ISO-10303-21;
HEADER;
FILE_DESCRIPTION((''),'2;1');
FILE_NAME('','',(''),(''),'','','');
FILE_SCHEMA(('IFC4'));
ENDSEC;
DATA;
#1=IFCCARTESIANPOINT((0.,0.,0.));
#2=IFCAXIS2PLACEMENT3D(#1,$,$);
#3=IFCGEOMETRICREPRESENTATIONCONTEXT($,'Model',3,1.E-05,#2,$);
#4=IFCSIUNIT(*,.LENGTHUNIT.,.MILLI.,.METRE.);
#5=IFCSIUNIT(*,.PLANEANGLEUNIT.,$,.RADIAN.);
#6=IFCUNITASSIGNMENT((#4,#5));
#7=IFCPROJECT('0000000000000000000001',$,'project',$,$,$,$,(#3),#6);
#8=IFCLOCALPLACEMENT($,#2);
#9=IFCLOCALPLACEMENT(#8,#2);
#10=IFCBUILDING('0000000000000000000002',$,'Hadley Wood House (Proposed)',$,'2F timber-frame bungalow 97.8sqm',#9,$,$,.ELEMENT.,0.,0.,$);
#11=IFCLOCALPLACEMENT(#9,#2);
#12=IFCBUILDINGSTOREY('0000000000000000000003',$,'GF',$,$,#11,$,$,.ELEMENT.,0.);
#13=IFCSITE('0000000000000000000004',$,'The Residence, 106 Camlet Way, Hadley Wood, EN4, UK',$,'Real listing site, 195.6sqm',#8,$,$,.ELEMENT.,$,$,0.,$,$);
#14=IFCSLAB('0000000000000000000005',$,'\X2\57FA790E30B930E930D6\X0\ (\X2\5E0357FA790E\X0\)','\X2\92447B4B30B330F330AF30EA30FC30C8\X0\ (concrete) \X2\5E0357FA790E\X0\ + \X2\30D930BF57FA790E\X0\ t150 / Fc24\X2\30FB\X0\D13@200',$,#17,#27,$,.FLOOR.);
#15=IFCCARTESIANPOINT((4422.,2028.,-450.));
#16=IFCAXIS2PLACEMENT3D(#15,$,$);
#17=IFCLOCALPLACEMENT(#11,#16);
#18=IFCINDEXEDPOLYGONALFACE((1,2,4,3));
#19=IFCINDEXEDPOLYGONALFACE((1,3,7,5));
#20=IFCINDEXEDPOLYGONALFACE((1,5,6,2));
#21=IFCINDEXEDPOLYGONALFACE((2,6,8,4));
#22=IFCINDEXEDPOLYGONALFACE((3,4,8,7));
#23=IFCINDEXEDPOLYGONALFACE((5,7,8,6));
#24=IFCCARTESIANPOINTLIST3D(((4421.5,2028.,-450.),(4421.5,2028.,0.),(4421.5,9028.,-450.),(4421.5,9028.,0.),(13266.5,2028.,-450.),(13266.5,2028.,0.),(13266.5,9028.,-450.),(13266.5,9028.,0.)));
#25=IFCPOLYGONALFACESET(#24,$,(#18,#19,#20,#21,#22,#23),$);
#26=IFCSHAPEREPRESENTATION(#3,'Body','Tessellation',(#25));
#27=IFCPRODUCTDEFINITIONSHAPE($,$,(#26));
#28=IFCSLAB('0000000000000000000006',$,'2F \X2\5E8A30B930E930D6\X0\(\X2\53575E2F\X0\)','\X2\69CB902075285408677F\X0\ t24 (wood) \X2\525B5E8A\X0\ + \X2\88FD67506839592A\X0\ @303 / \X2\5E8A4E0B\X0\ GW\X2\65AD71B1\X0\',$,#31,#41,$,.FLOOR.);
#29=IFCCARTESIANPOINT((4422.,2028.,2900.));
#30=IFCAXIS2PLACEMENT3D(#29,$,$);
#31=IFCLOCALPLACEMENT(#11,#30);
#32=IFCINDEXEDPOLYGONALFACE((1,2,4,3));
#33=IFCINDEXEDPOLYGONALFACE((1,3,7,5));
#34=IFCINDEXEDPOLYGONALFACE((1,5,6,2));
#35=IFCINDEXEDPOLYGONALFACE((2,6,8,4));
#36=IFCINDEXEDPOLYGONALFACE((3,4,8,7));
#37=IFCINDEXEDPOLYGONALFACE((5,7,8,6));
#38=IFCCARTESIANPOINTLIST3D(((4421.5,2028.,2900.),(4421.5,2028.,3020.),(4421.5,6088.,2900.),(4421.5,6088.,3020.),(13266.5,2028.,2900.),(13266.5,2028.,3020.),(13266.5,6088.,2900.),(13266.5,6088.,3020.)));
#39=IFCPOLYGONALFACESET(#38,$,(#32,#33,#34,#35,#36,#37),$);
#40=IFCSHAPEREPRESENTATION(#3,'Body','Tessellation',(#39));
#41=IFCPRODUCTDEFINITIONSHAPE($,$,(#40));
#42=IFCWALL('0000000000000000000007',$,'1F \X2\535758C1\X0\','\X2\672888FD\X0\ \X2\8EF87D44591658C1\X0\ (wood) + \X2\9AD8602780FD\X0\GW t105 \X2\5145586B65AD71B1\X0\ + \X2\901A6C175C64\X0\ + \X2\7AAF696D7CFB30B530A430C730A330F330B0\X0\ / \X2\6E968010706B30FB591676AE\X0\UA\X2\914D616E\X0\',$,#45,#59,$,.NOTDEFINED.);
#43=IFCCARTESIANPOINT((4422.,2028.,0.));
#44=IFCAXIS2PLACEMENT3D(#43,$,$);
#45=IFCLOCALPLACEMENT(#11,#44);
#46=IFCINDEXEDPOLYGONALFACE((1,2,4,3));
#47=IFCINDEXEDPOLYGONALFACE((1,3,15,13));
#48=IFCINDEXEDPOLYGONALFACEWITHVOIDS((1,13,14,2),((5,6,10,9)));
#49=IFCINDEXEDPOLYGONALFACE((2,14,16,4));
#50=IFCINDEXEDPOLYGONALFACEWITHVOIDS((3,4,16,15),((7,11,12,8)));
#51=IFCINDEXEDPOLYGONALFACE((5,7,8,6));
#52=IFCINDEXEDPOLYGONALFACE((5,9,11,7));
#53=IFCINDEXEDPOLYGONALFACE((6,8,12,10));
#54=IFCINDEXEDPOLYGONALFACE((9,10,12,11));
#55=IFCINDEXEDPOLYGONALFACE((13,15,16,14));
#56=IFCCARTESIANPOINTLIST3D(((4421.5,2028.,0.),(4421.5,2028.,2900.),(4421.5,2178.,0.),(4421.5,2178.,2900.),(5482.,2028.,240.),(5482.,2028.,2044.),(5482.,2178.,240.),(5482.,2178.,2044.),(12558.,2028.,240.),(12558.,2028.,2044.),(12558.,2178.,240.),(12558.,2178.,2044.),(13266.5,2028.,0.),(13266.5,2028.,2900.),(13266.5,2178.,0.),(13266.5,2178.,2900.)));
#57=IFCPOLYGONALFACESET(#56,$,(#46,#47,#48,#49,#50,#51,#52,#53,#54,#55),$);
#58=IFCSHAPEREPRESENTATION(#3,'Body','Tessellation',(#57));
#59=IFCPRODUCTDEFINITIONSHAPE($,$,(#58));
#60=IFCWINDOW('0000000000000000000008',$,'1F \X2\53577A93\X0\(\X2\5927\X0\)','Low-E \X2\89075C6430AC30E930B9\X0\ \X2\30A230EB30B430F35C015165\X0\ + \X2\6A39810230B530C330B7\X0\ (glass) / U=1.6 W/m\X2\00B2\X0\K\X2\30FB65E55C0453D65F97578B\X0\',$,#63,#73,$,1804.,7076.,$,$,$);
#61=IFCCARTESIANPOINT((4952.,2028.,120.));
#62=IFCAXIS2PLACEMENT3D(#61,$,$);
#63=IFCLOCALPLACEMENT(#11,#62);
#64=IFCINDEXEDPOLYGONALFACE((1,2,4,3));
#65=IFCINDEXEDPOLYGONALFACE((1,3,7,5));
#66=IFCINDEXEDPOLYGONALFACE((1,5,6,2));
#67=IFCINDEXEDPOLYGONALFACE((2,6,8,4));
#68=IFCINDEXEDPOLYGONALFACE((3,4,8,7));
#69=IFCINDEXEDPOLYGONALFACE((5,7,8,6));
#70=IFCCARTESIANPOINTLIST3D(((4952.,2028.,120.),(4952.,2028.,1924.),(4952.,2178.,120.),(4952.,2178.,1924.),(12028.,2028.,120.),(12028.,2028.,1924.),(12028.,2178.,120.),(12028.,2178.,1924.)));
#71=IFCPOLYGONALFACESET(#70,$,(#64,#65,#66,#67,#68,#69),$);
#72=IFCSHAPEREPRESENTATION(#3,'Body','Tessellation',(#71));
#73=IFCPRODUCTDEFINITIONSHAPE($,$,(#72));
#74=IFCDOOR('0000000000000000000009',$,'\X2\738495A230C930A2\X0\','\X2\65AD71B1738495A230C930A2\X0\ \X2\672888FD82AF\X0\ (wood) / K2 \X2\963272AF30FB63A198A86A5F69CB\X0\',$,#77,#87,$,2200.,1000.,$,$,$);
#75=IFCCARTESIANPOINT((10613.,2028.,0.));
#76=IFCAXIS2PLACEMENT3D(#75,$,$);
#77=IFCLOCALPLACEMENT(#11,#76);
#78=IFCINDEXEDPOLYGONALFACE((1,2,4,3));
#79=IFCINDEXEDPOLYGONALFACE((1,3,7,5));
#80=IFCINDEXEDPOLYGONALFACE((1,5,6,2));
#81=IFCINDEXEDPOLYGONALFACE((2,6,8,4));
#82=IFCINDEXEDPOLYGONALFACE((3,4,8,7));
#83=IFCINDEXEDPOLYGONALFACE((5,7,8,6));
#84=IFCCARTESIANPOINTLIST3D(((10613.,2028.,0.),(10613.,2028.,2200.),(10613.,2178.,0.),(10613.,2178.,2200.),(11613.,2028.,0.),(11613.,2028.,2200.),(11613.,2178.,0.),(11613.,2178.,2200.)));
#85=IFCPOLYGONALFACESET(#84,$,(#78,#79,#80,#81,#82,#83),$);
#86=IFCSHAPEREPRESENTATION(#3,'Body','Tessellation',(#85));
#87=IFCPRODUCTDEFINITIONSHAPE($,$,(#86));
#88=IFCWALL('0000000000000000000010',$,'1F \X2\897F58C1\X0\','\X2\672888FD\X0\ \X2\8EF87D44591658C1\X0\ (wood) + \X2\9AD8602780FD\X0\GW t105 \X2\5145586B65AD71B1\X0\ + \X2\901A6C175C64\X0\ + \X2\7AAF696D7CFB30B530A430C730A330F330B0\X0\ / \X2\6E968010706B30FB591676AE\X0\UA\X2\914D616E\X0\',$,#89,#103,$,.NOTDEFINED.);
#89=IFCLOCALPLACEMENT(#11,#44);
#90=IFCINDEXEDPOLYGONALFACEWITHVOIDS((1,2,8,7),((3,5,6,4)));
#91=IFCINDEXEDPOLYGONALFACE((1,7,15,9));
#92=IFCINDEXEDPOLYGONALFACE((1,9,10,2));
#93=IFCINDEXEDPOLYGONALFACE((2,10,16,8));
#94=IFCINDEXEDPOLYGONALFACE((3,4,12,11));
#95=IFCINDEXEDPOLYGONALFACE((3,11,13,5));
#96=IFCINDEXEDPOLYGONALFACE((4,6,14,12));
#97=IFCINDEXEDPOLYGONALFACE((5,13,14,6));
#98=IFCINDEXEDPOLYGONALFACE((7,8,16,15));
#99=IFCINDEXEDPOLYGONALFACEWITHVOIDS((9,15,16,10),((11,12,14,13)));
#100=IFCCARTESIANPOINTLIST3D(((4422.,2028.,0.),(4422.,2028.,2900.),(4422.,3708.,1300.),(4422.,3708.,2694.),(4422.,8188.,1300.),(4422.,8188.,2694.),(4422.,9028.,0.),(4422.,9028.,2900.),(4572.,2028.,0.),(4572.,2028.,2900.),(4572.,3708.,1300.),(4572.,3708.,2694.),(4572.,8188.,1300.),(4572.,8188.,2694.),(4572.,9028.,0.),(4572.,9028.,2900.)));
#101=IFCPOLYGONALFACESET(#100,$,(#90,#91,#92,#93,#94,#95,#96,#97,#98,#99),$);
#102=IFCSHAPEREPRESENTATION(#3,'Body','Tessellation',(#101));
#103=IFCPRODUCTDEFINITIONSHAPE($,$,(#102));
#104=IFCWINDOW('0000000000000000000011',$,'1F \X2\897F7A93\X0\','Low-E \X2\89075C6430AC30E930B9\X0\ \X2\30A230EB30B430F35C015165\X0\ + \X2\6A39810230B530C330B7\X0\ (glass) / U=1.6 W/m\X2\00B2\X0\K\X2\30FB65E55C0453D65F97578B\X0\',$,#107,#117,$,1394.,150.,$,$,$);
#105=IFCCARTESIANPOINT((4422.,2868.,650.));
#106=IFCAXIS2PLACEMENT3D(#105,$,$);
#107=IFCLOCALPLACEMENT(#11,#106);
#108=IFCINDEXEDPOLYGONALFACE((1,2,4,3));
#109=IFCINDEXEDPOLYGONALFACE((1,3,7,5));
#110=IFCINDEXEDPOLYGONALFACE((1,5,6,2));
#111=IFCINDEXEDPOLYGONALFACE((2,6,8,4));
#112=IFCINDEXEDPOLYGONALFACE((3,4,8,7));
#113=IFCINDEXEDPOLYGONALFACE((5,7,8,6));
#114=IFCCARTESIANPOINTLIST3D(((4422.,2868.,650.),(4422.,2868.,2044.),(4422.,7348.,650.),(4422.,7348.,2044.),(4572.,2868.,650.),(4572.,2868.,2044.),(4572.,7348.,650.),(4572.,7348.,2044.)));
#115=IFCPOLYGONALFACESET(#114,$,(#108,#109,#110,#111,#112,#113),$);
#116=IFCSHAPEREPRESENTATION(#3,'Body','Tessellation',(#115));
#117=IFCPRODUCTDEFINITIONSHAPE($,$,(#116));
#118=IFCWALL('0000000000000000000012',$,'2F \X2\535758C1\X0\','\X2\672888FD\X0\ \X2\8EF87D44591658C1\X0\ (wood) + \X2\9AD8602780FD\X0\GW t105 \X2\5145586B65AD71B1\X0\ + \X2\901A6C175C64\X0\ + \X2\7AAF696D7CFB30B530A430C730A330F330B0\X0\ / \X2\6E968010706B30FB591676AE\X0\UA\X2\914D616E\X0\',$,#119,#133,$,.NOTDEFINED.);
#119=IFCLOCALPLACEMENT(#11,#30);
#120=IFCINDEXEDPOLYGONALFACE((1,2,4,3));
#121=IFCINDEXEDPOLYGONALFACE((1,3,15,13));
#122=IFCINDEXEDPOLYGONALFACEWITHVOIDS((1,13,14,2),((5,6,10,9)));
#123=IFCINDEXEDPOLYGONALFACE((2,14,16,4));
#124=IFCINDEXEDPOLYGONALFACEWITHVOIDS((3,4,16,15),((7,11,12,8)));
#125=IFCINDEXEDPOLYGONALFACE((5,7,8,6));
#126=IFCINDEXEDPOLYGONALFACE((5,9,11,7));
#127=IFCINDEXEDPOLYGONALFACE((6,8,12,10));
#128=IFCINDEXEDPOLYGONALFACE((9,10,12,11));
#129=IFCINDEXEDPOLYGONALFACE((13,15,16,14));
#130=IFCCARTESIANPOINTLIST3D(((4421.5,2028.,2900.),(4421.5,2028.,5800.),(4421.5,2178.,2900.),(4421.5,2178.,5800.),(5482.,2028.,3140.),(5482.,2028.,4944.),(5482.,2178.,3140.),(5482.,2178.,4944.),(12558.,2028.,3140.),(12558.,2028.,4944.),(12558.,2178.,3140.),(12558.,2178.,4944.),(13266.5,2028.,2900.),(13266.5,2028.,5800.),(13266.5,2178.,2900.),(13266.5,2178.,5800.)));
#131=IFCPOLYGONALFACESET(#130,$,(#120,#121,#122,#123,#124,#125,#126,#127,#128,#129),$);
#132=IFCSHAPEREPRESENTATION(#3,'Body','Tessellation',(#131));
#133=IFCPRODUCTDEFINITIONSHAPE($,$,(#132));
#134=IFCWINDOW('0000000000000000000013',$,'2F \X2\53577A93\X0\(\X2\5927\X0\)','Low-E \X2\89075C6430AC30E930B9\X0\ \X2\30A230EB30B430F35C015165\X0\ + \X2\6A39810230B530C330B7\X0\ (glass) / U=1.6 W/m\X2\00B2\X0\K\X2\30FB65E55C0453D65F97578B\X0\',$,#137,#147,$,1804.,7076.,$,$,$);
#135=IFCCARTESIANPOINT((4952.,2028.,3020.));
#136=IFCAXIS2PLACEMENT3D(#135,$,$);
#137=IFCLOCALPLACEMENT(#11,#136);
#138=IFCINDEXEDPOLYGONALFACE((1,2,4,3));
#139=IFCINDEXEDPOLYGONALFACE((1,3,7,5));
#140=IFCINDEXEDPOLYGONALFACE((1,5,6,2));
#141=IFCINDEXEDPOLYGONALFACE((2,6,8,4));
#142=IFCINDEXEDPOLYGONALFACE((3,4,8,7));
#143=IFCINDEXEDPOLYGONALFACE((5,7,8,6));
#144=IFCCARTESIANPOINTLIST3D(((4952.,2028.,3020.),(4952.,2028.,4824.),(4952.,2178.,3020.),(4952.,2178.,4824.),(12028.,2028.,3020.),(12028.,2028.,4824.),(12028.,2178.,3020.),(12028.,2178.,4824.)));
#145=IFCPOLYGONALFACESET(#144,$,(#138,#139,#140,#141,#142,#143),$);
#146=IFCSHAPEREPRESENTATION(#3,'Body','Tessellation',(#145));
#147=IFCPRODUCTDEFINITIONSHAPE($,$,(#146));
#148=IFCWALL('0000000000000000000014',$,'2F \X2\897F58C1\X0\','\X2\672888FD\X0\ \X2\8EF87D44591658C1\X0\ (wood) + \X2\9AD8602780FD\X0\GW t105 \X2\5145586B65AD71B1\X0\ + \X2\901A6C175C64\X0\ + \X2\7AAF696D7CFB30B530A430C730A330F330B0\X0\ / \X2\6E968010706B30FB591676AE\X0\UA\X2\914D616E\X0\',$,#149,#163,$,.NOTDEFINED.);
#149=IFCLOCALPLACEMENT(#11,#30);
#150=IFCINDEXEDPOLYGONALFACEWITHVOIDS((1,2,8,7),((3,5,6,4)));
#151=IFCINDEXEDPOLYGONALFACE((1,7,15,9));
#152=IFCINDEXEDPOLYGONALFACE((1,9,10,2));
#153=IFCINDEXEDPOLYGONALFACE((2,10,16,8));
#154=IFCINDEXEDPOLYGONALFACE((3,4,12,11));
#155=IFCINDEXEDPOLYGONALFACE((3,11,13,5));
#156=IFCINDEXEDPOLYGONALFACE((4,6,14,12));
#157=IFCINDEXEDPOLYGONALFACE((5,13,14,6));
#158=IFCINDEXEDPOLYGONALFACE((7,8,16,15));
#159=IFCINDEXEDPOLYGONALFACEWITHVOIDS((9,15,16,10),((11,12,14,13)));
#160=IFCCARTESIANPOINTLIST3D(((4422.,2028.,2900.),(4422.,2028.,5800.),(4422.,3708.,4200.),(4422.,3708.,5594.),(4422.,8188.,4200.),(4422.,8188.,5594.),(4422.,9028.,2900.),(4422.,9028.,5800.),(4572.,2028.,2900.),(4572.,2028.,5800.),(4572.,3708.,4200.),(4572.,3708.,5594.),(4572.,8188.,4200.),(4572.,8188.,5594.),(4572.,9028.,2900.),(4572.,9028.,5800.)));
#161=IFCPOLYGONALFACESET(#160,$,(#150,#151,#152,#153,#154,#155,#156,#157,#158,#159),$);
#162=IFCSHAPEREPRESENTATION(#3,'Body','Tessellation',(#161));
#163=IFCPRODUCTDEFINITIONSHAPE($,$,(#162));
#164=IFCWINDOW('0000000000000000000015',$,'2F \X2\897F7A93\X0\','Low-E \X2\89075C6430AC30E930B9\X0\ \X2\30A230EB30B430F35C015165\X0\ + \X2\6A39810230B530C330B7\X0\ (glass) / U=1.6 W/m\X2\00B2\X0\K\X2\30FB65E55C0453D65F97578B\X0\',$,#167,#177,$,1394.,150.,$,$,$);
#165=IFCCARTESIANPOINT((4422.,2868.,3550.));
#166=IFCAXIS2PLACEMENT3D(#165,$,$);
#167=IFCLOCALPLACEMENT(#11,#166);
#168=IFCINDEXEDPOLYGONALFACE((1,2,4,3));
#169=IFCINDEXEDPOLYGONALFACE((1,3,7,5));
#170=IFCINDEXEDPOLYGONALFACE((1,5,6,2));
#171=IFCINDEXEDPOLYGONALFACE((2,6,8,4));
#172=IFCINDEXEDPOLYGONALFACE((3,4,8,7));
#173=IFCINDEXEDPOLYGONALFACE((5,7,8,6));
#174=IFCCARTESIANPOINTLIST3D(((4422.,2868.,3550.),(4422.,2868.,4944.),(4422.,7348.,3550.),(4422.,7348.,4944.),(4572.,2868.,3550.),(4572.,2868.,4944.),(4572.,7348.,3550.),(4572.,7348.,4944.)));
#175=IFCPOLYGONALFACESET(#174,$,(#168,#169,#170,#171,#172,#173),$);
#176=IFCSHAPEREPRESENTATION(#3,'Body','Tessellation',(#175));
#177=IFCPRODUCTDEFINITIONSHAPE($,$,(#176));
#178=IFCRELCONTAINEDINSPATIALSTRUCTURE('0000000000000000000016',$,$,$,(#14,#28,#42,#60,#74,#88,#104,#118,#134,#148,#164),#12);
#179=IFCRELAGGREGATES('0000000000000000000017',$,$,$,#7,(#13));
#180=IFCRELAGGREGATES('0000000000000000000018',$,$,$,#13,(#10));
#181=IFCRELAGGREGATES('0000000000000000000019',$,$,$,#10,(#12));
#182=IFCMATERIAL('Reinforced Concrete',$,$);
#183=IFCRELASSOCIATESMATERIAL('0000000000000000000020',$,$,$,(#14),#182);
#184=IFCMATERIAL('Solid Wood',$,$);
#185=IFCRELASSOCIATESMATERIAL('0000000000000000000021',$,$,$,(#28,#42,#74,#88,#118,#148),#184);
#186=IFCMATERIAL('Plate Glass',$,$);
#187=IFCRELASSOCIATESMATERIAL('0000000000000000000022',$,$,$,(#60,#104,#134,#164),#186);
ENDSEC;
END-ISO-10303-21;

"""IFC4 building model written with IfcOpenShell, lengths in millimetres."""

from ifc_helpers import new_model, si_unit, frame, frame_2d, origin, place, context, project, spatial, rectangle, extrude, material, element, fill, save


model = new_model("IFC4")

# Units and contexts
model_context = context("Model", 3, precision=1e-05, world=origin())
ifc_project = project(units=[si_unit("LENGTHUNIT", "METRE", prefix="MILLI"), si_unit("PLANEANGLEUNIT", "RADIAN")], contexts=[model_context])

# Site, building, storey
site_placement = place(None, origin())
site = spatial("IfcSite", under=ifc_project, at=site_placement, Name="The Residence, 106 Camlet Way, Hadley Wood, EN4, UK", ObjectType="Real listing site, 195.6sqm", CompositionType="ELEMENT", RefElevation=0.0)
building_placement = place(site_placement, origin())
building = spatial("IfcBuilding", under=site, at=building_placement, Name="Hadley Wood House (Proposed)", ObjectType="2F timber-frame bungalow 97.8sqm", CompositionType="ELEMENT", ElevationOfRefHeight=0.0, ElevationOfTerrain=0.0)
storey_placement = place(building_placement, origin())
storey = spatial("IfcBuildingStorey", under=building, at=storey_placement, Name="GF", CompositionType="ELEMENT", Elevation=0.0)

# Slabs
ifc_material_1 = material(Name="Reinforced Concrete")
slab_1_placement = place(storey_placement, frame((4422.0, 2028.0, -450.0)))
element("IfcSlab", 1, at=slab_1_placement, inside=storey, material=ifc_material_1, Name="基礎スラブ (布基礎)", Description="鉄筋コンクリート (concrete) 布基礎 + ベタ基礎 t150 / Fc24・D13@200", PredefinedType="FLOOR", context=model_context, shape_type="SweptSolid", body=[
    extrude(rectangle(XDim=8845.0, YDim=7000.0, at=frame_2d((4422.0, 3500.0))), frame((4422.0, 2028.0, -450.0)), (0.0, 0.0, 1.0), 450.0),
])
ifc_material_2 = material(Name="Solid Wood")
slab_2_placement = place(storey_placement, frame((4422.0, 2028.0, 2900.0)))
element("IfcSlab", 2, at=slab_2_placement, inside=storey, material=ifc_material_2, Name="2F 床スラブ(南帯)", Description="構造用合板 t24 (wood) 剛床 + 製材根太 @303 / 床下 GW断熱", PredefinedType="FLOOR", context=model_context, shape_type="SweptSolid", body=[
    extrude(rectangle(XDim=8845.0, YDim=4060.0, at=frame_2d((4422.0, 2030.0))), frame((4422.0, 2028.0, 2900.0)), (0.0, 0.0, 1.0), 120.0),
])

# Wall, openings, window, door
wall_1_placement = place(storey_placement, frame((4422.0, 2028.0, 0.0)))
wall_1 = element("IfcWall", 3, at=wall_1_placement, inside=storey, material=ifc_material_2, Name="1F 南壁", Description="木製 軸組外壁 (wood) + 高性能GW t105 充填断熱 + 通気層 + 窯業系サイディング / 準耐火・外皮UA配慮", PredefinedType="NOTDEFINED", context=model_context, shape_type="SweptSolid", body=[
    extrude(rectangle(XDim=8845.0, YDim=150.0, at=frame_2d((4422.0, 75.0))), frame((4422.0, 2028.0, 0.0)), (0.0, 0.0, 1.0), 2900.0),
])
opening_1_placement = place(storey_placement, frame((4952.0, 2028.0, 120.0)))
opening_1 = element("IfcOpeningElement", 4, at=opening_1_placement, cuts=wall_1, PredefinedType="NOTDEFINED", context=model_context, shape_type="SweptSolid", body=[
    extrude(rectangle(XDim=7076.0, YDim=150.0, at=frame_2d((3538.0, 75.0))), frame((4952.0, 2028.0, 120.0)), (0.0, 0.0, 1.0), 1804.0),
])
opening_2_placement = place(storey_placement, frame((10613.0, 2028.0, 0.0)))
opening_2 = element("IfcOpeningElement", 5, at=opening_2_placement, cuts=wall_1, PredefinedType="NOTDEFINED", context=model_context, shape_type="SweptSolid", body=[
    extrude(rectangle(XDim=1000.0, YDim=150.0, at=frame_2d((500.0, 75.0))), frame((10613.0, 2028.0, 0.0)), (0.0, 0.0, 1.0), 2200.0),
])
ifc_material_3 = material(Name="Plate Glass")
window_1_placement = place(storey_placement, frame((4952.0, 2028.0, 120.0)))
window_1 = element("IfcWindow", 6, at=window_1_placement, inside=storey, material=ifc_material_3, Name="1F 南窓(大)", Description="Low-E 複層ガラス アルゴン封入 + 樹脂サッシ (glass) / U=1.6 W/m²K・日射取得型", OverallHeight=1804.0, OverallWidth=7076.0, context=model_context, shape_type="SweptSolid", body=[
    extrude(rectangle(XDim=7076.0, YDim=150.0, at=frame_2d((3538.0, 75.0))), frame((4952.0, 2028.0, 120.0)), (0.0, 0.0, 1.0), 1804.0),
])
fill(opening_1, window_1)
door_placement = place(storey_placement, frame((10613.0, 2028.0, 0.0)))
door = element("IfcDoor", 7, at=door_placement, inside=storey, material=ifc_material_2, Name="玄関ドア", Description="断熱玄関ドア 木製芯 (wood) / K2 防犯・採風機構", OverallHeight=2200.0, OverallWidth=1000.0, context=model_context, shape_type="SweptSolid", body=[
    extrude(rectangle(XDim=1000.0, YDim=150.0, at=frame_2d((500.0, 75.0))), frame((10613.0, 2028.0, 0.0)), (0.0, 0.0, 1.0), 2200.0),
])
fill(opening_2, door)

# Wall, opening, window
wall_2_placement = place(storey_placement, frame((4422.0, 2028.0, 0.0)))
wall_2 = element("IfcWall", 8, at=wall_2_placement, inside=storey, material=ifc_material_2, Name="1F 西壁", Description="木製 軸組外壁 (wood) + 高性能GW t105 充填断熱 + 通気層 + 窯業系サイディング / 準耐火・外皮UA配慮", PredefinedType="NOTDEFINED", context=model_context, shape_type="SweptSolid", body=[
    extrude(rectangle(XDim=150.0, YDim=7000.0, at=frame_2d((75.0, 3500.0))), frame((4422.0, 2028.0, 0.0)), (0.0, 0.0, 1.0), 2900.0),
])
opening_3_placement = place(storey_placement, frame((4422.0, 2868.0, 650.0)))
opening_3 = element("IfcOpeningElement", 9, at=opening_3_placement, cuts=wall_2, PredefinedType="NOTDEFINED", context=model_context, shape_type="SweptSolid", body=[
    extrude(rectangle(XDim=150.0, YDim=4480.0, at=frame_2d((75.0, 2240.0))), frame((4422.0, 2868.0, 650.0)), (0.0, 0.0, 1.0), 1394.0),
])
window_2_placement = place(storey_placement, frame((4422.0, 2868.0, 650.0)))
window_2 = element("IfcWindow", 10, at=window_2_placement, inside=storey, material=ifc_material_3, Name="1F 西窓", Description="Low-E 複層ガラス アルゴン封入 + 樹脂サッシ (glass) / U=1.6 W/m²K・日射取得型", OverallHeight=1394.0, OverallWidth=150.0, context=model_context, shape_type="SweptSolid", body=[
    extrude(rectangle(XDim=150.0, YDim=4480.0, at=frame_2d((75.0, 2240.0))), frame((4422.0, 2868.0, 650.0)), (0.0, 0.0, 1.0), 1394.0),
])
fill(opening_3, window_2)

# Walls, openings, windows
wall_3_placement = place(storey_placement, frame((4422.0, 2028.0, 2900.0)))
wall_3 = element("IfcWall", 11, at=wall_3_placement, inside=storey, material=ifc_material_2, Name="2F 南壁", Description="木製 軸組外壁 (wood) + 高性能GW t105 充填断熱 + 通気層 + 窯業系サイディング / 準耐火・外皮UA配慮", PredefinedType="NOTDEFINED", context=model_context, shape_type="SweptSolid", body=[
    extrude(rectangle(XDim=8845.0, YDim=150.0, at=frame_2d((4422.0, 75.0))), frame((4422.0, 2028.0, 2900.0)), (0.0, 0.0, 1.0), 2900.0),
])
opening_4_placement = place(storey_placement, frame((4952.0, 2028.0, 3020.0)))
opening_4 = element("IfcOpeningElement", 12, at=opening_4_placement, cuts=wall_3, PredefinedType="NOTDEFINED", context=model_context, shape_type="SweptSolid", body=[
    extrude(rectangle(XDim=7076.0, YDim=150.0, at=frame_2d((3538.0, 75.0))), frame((4952.0, 2028.0, 3020.0)), (0.0, 0.0, 1.0), 1804.0),
])
window_3_placement = place(storey_placement, frame((4952.0, 2028.0, 3020.0)))
window_3 = element("IfcWindow", 13, at=window_3_placement, inside=storey, material=ifc_material_3, Name="2F 南窓(大)", Description="Low-E 複層ガラス アルゴン封入 + 樹脂サッシ (glass) / U=1.6 W/m²K・日射取得型", OverallHeight=1804.0, OverallWidth=7076.0, context=model_context, shape_type="SweptSolid", body=[
    extrude(rectangle(XDim=7076.0, YDim=150.0, at=frame_2d((3538.0, 75.0))), frame((4952.0, 2028.0, 3020.0)), (0.0, 0.0, 1.0), 1804.0),
])
fill(opening_4, window_3)
wall_4_placement = place(storey_placement, frame((4422.0, 2028.0, 2900.0)))
wall_4 = element("IfcWall", 14, at=wall_4_placement, inside=storey, material=ifc_material_2, Name="2F 西壁", Description="木製 軸組外壁 (wood) + 高性能GW t105 充填断熱 + 通気層 + 窯業系サイディング / 準耐火・外皮UA配慮", PredefinedType="NOTDEFINED", context=model_context, shape_type="SweptSolid", body=[
    extrude(rectangle(XDim=150.0, YDim=7000.0, at=frame_2d((75.0, 3500.0))), frame((4422.0, 2028.0, 2900.0)), (0.0, 0.0, 1.0), 2900.0),
])
opening_5_placement = place(storey_placement, frame((4422.0, 2868.0, 3550.0)))
opening_5 = element("IfcOpeningElement", 15, at=opening_5_placement, cuts=wall_4, PredefinedType="NOTDEFINED", context=model_context, shape_type="SweptSolid", body=[
    extrude(rectangle(XDim=150.0, YDim=4480.0, at=frame_2d((75.0, 2240.0))), frame((4422.0, 2868.0, 3550.0)), (0.0, 0.0, 1.0), 1394.0),
])
window_4_placement = place(storey_placement, frame((4422.0, 2868.0, 3550.0)))
window_4 = element("IfcWindow", 16, at=window_4_placement, inside=storey, material=ifc_material_3, Name="2F 西窓", Description="Low-E 複層ガラス アルゴン封入 + 樹脂サッシ (glass) / U=1.6 W/m²K・日射取得型", OverallHeight=1394.0, OverallWidth=150.0, context=model_context, shape_type="SweptSolid", body=[
    extrude(rectangle(XDim=150.0, YDim=4480.0, at=frame_2d((75.0, 2240.0))), frame((4422.0, 2868.0, 3550.0)), (0.0, 0.0, 1.0), 1394.0),
])
fill(opening_5, window_4)

save(model, "model.ifc")
